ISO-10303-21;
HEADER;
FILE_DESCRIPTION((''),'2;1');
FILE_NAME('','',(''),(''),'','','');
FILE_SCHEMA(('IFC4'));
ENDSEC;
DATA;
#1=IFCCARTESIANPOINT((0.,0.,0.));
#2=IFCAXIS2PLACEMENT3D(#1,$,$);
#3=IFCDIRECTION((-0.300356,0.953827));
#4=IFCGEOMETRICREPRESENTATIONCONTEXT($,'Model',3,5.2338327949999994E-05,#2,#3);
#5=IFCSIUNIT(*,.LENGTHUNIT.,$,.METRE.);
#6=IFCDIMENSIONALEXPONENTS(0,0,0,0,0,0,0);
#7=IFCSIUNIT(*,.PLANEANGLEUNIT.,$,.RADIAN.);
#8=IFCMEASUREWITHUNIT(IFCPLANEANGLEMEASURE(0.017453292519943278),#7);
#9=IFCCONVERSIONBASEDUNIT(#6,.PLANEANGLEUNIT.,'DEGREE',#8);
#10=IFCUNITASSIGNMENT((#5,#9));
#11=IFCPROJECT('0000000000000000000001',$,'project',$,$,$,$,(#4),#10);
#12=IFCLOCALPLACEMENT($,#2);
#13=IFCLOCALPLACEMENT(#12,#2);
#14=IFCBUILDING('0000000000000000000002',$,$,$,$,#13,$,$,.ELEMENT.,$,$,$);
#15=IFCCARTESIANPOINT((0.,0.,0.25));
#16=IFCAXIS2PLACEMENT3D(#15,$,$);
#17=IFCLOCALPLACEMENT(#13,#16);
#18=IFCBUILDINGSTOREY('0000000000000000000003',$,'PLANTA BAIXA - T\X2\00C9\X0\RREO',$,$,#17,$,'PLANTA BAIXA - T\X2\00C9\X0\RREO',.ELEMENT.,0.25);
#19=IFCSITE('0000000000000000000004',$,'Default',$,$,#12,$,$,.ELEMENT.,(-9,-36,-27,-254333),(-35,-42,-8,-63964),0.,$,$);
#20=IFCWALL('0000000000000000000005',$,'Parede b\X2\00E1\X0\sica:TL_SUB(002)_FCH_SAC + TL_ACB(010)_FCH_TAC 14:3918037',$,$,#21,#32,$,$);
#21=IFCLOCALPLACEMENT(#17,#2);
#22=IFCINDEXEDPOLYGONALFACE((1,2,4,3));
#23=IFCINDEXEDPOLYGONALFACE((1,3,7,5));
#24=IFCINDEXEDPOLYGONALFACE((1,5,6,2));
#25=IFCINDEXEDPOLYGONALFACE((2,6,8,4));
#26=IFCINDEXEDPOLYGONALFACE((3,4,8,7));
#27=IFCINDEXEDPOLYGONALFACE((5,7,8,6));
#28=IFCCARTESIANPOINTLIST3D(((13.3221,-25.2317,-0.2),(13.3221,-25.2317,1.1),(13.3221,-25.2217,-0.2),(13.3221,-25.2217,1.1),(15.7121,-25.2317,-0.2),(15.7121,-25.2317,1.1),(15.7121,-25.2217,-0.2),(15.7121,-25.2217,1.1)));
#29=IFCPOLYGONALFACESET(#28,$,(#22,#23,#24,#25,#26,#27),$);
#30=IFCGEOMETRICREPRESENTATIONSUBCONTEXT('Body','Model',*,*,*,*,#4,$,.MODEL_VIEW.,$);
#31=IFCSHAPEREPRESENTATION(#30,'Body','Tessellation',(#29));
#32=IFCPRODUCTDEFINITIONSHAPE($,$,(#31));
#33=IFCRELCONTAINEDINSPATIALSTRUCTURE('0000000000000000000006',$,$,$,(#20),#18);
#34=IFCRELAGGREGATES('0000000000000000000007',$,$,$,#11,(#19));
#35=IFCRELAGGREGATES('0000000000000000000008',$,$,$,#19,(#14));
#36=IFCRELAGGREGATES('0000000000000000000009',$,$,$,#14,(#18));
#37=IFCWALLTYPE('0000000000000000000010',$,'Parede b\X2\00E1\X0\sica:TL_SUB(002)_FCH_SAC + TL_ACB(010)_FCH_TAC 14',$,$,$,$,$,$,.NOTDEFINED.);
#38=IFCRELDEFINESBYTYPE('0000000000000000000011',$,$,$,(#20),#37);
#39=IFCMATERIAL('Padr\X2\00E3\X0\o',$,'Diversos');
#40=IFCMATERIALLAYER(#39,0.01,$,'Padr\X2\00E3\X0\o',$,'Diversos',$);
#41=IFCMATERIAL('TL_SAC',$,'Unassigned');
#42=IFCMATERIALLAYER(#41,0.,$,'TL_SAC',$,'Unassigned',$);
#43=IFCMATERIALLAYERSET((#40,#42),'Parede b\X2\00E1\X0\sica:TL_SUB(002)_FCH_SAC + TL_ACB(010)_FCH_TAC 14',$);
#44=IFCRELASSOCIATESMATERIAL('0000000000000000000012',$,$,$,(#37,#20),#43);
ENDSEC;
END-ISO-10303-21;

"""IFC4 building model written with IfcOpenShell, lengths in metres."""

from ifc_helpers import new_model, entity, si_unit, converted_unit, direction, frame, frame_2d, origin, place, context, subcontext, project, spatial, rectangle, extrude, material, layer, layer_set, layer_usage, type_object, element, save


model = new_model("IFC4")

# Units and contexts
model_context = context("Model", 3, precision=5.2338327949999994e-05, world=origin(), true_north=direction((-0.300356, 0.953827)))
body_context = subcontext(model_context, "Body", "Model", "MODEL_VIEW")
ifc_project = project(units=[si_unit("LENGTHUNIT", "METRE"), converted_unit("PLANEANGLEUNIT", "DEGREE", entity("IfcPlaneAngleMeasure", 0.017453292519943278), si_unit("PLANEANGLEUNIT", "RADIAN"), dimensions=[0, 0, 0, 0, 0, 0, 0])], contexts=[model_context])

# Site, building, storey
site_placement = place(None, origin())
site = spatial("IfcSite", under=ifc_project, at=site_placement, Name="Default", CompositionType="ELEMENT", RefLatitude=(-9, -36, -27, -254333), RefLongitude=(-35, -42, -8, -63964), RefElevation=0.0)
building_placement = place(site_placement, origin())
building = spatial("IfcBuilding", under=site, at=building_placement, CompositionType="ELEMENT")
storey_placement = place(building_placement, frame((0.0, 0.0, 0.25)))
storey = spatial("IfcBuildingStorey", under=building, at=storey_placement, Name="PLANTA BAIXA - TÉRREO", LongName="PLANTA BAIXA - TÉRREO", CompositionType="ELEMENT", Elevation=0.25)

# Shared definitions
ifc_material_1 = material(Name="TL_SAC", Category="Unassigned")

# Wall
ifc_material_2 = material(Name="Padrão", Category="Diversos")
ifc_layer_1 = layer(ifc_material_2, 0.01, Name="Padrão", Category="Diversos")
ifc_layer_2 = layer(ifc_material_1, 0.0, Name="TL_SAC", Category="Unassigned")
ifc_layer_set_1 = layer_set([ifc_layer_1, ifc_layer_2], Name="Parede básica:TL_SUB(002)_FCH_SAC + TL_ACB(010)_FCH_TAC 14")
ifc_layer_usage_1 = layer_usage(ifc_layer_set_1, "AXIS2", "NEGATIVE", 0.005)
wall_type_1 = type_object("IfcWallType", Name="Parede básica:TL_SUB(002)_FCH_SAC + TL_ACB(010)_FCH_TAC 14", PredefinedType="NOTDEFINED", material=ifc_layer_set_1)
wall_1_placement = place(storey_placement, frame((13.3221, -25.2267, -0.2)))
element("IfcWall", 1, at=wall_1_placement, inside=storey, type_object=wall_type_1, material=ifc_layer_usage_1, Name="Parede básica:TL_SUB(002)_FCH_SAC + TL_ACB(010)_FCH_TAC 14:3918037", context=body_context, shape_type="SweptSolid", body=[
    extrude(rectangle(XDim=2.39, YDim=0.01, at=frame_2d((1.195, 0.0), x_axis=(-1.0, 0.0))), origin(), (0.0, 0.0, 1.0), 1.3),
])

save(model, "model.ifc")
